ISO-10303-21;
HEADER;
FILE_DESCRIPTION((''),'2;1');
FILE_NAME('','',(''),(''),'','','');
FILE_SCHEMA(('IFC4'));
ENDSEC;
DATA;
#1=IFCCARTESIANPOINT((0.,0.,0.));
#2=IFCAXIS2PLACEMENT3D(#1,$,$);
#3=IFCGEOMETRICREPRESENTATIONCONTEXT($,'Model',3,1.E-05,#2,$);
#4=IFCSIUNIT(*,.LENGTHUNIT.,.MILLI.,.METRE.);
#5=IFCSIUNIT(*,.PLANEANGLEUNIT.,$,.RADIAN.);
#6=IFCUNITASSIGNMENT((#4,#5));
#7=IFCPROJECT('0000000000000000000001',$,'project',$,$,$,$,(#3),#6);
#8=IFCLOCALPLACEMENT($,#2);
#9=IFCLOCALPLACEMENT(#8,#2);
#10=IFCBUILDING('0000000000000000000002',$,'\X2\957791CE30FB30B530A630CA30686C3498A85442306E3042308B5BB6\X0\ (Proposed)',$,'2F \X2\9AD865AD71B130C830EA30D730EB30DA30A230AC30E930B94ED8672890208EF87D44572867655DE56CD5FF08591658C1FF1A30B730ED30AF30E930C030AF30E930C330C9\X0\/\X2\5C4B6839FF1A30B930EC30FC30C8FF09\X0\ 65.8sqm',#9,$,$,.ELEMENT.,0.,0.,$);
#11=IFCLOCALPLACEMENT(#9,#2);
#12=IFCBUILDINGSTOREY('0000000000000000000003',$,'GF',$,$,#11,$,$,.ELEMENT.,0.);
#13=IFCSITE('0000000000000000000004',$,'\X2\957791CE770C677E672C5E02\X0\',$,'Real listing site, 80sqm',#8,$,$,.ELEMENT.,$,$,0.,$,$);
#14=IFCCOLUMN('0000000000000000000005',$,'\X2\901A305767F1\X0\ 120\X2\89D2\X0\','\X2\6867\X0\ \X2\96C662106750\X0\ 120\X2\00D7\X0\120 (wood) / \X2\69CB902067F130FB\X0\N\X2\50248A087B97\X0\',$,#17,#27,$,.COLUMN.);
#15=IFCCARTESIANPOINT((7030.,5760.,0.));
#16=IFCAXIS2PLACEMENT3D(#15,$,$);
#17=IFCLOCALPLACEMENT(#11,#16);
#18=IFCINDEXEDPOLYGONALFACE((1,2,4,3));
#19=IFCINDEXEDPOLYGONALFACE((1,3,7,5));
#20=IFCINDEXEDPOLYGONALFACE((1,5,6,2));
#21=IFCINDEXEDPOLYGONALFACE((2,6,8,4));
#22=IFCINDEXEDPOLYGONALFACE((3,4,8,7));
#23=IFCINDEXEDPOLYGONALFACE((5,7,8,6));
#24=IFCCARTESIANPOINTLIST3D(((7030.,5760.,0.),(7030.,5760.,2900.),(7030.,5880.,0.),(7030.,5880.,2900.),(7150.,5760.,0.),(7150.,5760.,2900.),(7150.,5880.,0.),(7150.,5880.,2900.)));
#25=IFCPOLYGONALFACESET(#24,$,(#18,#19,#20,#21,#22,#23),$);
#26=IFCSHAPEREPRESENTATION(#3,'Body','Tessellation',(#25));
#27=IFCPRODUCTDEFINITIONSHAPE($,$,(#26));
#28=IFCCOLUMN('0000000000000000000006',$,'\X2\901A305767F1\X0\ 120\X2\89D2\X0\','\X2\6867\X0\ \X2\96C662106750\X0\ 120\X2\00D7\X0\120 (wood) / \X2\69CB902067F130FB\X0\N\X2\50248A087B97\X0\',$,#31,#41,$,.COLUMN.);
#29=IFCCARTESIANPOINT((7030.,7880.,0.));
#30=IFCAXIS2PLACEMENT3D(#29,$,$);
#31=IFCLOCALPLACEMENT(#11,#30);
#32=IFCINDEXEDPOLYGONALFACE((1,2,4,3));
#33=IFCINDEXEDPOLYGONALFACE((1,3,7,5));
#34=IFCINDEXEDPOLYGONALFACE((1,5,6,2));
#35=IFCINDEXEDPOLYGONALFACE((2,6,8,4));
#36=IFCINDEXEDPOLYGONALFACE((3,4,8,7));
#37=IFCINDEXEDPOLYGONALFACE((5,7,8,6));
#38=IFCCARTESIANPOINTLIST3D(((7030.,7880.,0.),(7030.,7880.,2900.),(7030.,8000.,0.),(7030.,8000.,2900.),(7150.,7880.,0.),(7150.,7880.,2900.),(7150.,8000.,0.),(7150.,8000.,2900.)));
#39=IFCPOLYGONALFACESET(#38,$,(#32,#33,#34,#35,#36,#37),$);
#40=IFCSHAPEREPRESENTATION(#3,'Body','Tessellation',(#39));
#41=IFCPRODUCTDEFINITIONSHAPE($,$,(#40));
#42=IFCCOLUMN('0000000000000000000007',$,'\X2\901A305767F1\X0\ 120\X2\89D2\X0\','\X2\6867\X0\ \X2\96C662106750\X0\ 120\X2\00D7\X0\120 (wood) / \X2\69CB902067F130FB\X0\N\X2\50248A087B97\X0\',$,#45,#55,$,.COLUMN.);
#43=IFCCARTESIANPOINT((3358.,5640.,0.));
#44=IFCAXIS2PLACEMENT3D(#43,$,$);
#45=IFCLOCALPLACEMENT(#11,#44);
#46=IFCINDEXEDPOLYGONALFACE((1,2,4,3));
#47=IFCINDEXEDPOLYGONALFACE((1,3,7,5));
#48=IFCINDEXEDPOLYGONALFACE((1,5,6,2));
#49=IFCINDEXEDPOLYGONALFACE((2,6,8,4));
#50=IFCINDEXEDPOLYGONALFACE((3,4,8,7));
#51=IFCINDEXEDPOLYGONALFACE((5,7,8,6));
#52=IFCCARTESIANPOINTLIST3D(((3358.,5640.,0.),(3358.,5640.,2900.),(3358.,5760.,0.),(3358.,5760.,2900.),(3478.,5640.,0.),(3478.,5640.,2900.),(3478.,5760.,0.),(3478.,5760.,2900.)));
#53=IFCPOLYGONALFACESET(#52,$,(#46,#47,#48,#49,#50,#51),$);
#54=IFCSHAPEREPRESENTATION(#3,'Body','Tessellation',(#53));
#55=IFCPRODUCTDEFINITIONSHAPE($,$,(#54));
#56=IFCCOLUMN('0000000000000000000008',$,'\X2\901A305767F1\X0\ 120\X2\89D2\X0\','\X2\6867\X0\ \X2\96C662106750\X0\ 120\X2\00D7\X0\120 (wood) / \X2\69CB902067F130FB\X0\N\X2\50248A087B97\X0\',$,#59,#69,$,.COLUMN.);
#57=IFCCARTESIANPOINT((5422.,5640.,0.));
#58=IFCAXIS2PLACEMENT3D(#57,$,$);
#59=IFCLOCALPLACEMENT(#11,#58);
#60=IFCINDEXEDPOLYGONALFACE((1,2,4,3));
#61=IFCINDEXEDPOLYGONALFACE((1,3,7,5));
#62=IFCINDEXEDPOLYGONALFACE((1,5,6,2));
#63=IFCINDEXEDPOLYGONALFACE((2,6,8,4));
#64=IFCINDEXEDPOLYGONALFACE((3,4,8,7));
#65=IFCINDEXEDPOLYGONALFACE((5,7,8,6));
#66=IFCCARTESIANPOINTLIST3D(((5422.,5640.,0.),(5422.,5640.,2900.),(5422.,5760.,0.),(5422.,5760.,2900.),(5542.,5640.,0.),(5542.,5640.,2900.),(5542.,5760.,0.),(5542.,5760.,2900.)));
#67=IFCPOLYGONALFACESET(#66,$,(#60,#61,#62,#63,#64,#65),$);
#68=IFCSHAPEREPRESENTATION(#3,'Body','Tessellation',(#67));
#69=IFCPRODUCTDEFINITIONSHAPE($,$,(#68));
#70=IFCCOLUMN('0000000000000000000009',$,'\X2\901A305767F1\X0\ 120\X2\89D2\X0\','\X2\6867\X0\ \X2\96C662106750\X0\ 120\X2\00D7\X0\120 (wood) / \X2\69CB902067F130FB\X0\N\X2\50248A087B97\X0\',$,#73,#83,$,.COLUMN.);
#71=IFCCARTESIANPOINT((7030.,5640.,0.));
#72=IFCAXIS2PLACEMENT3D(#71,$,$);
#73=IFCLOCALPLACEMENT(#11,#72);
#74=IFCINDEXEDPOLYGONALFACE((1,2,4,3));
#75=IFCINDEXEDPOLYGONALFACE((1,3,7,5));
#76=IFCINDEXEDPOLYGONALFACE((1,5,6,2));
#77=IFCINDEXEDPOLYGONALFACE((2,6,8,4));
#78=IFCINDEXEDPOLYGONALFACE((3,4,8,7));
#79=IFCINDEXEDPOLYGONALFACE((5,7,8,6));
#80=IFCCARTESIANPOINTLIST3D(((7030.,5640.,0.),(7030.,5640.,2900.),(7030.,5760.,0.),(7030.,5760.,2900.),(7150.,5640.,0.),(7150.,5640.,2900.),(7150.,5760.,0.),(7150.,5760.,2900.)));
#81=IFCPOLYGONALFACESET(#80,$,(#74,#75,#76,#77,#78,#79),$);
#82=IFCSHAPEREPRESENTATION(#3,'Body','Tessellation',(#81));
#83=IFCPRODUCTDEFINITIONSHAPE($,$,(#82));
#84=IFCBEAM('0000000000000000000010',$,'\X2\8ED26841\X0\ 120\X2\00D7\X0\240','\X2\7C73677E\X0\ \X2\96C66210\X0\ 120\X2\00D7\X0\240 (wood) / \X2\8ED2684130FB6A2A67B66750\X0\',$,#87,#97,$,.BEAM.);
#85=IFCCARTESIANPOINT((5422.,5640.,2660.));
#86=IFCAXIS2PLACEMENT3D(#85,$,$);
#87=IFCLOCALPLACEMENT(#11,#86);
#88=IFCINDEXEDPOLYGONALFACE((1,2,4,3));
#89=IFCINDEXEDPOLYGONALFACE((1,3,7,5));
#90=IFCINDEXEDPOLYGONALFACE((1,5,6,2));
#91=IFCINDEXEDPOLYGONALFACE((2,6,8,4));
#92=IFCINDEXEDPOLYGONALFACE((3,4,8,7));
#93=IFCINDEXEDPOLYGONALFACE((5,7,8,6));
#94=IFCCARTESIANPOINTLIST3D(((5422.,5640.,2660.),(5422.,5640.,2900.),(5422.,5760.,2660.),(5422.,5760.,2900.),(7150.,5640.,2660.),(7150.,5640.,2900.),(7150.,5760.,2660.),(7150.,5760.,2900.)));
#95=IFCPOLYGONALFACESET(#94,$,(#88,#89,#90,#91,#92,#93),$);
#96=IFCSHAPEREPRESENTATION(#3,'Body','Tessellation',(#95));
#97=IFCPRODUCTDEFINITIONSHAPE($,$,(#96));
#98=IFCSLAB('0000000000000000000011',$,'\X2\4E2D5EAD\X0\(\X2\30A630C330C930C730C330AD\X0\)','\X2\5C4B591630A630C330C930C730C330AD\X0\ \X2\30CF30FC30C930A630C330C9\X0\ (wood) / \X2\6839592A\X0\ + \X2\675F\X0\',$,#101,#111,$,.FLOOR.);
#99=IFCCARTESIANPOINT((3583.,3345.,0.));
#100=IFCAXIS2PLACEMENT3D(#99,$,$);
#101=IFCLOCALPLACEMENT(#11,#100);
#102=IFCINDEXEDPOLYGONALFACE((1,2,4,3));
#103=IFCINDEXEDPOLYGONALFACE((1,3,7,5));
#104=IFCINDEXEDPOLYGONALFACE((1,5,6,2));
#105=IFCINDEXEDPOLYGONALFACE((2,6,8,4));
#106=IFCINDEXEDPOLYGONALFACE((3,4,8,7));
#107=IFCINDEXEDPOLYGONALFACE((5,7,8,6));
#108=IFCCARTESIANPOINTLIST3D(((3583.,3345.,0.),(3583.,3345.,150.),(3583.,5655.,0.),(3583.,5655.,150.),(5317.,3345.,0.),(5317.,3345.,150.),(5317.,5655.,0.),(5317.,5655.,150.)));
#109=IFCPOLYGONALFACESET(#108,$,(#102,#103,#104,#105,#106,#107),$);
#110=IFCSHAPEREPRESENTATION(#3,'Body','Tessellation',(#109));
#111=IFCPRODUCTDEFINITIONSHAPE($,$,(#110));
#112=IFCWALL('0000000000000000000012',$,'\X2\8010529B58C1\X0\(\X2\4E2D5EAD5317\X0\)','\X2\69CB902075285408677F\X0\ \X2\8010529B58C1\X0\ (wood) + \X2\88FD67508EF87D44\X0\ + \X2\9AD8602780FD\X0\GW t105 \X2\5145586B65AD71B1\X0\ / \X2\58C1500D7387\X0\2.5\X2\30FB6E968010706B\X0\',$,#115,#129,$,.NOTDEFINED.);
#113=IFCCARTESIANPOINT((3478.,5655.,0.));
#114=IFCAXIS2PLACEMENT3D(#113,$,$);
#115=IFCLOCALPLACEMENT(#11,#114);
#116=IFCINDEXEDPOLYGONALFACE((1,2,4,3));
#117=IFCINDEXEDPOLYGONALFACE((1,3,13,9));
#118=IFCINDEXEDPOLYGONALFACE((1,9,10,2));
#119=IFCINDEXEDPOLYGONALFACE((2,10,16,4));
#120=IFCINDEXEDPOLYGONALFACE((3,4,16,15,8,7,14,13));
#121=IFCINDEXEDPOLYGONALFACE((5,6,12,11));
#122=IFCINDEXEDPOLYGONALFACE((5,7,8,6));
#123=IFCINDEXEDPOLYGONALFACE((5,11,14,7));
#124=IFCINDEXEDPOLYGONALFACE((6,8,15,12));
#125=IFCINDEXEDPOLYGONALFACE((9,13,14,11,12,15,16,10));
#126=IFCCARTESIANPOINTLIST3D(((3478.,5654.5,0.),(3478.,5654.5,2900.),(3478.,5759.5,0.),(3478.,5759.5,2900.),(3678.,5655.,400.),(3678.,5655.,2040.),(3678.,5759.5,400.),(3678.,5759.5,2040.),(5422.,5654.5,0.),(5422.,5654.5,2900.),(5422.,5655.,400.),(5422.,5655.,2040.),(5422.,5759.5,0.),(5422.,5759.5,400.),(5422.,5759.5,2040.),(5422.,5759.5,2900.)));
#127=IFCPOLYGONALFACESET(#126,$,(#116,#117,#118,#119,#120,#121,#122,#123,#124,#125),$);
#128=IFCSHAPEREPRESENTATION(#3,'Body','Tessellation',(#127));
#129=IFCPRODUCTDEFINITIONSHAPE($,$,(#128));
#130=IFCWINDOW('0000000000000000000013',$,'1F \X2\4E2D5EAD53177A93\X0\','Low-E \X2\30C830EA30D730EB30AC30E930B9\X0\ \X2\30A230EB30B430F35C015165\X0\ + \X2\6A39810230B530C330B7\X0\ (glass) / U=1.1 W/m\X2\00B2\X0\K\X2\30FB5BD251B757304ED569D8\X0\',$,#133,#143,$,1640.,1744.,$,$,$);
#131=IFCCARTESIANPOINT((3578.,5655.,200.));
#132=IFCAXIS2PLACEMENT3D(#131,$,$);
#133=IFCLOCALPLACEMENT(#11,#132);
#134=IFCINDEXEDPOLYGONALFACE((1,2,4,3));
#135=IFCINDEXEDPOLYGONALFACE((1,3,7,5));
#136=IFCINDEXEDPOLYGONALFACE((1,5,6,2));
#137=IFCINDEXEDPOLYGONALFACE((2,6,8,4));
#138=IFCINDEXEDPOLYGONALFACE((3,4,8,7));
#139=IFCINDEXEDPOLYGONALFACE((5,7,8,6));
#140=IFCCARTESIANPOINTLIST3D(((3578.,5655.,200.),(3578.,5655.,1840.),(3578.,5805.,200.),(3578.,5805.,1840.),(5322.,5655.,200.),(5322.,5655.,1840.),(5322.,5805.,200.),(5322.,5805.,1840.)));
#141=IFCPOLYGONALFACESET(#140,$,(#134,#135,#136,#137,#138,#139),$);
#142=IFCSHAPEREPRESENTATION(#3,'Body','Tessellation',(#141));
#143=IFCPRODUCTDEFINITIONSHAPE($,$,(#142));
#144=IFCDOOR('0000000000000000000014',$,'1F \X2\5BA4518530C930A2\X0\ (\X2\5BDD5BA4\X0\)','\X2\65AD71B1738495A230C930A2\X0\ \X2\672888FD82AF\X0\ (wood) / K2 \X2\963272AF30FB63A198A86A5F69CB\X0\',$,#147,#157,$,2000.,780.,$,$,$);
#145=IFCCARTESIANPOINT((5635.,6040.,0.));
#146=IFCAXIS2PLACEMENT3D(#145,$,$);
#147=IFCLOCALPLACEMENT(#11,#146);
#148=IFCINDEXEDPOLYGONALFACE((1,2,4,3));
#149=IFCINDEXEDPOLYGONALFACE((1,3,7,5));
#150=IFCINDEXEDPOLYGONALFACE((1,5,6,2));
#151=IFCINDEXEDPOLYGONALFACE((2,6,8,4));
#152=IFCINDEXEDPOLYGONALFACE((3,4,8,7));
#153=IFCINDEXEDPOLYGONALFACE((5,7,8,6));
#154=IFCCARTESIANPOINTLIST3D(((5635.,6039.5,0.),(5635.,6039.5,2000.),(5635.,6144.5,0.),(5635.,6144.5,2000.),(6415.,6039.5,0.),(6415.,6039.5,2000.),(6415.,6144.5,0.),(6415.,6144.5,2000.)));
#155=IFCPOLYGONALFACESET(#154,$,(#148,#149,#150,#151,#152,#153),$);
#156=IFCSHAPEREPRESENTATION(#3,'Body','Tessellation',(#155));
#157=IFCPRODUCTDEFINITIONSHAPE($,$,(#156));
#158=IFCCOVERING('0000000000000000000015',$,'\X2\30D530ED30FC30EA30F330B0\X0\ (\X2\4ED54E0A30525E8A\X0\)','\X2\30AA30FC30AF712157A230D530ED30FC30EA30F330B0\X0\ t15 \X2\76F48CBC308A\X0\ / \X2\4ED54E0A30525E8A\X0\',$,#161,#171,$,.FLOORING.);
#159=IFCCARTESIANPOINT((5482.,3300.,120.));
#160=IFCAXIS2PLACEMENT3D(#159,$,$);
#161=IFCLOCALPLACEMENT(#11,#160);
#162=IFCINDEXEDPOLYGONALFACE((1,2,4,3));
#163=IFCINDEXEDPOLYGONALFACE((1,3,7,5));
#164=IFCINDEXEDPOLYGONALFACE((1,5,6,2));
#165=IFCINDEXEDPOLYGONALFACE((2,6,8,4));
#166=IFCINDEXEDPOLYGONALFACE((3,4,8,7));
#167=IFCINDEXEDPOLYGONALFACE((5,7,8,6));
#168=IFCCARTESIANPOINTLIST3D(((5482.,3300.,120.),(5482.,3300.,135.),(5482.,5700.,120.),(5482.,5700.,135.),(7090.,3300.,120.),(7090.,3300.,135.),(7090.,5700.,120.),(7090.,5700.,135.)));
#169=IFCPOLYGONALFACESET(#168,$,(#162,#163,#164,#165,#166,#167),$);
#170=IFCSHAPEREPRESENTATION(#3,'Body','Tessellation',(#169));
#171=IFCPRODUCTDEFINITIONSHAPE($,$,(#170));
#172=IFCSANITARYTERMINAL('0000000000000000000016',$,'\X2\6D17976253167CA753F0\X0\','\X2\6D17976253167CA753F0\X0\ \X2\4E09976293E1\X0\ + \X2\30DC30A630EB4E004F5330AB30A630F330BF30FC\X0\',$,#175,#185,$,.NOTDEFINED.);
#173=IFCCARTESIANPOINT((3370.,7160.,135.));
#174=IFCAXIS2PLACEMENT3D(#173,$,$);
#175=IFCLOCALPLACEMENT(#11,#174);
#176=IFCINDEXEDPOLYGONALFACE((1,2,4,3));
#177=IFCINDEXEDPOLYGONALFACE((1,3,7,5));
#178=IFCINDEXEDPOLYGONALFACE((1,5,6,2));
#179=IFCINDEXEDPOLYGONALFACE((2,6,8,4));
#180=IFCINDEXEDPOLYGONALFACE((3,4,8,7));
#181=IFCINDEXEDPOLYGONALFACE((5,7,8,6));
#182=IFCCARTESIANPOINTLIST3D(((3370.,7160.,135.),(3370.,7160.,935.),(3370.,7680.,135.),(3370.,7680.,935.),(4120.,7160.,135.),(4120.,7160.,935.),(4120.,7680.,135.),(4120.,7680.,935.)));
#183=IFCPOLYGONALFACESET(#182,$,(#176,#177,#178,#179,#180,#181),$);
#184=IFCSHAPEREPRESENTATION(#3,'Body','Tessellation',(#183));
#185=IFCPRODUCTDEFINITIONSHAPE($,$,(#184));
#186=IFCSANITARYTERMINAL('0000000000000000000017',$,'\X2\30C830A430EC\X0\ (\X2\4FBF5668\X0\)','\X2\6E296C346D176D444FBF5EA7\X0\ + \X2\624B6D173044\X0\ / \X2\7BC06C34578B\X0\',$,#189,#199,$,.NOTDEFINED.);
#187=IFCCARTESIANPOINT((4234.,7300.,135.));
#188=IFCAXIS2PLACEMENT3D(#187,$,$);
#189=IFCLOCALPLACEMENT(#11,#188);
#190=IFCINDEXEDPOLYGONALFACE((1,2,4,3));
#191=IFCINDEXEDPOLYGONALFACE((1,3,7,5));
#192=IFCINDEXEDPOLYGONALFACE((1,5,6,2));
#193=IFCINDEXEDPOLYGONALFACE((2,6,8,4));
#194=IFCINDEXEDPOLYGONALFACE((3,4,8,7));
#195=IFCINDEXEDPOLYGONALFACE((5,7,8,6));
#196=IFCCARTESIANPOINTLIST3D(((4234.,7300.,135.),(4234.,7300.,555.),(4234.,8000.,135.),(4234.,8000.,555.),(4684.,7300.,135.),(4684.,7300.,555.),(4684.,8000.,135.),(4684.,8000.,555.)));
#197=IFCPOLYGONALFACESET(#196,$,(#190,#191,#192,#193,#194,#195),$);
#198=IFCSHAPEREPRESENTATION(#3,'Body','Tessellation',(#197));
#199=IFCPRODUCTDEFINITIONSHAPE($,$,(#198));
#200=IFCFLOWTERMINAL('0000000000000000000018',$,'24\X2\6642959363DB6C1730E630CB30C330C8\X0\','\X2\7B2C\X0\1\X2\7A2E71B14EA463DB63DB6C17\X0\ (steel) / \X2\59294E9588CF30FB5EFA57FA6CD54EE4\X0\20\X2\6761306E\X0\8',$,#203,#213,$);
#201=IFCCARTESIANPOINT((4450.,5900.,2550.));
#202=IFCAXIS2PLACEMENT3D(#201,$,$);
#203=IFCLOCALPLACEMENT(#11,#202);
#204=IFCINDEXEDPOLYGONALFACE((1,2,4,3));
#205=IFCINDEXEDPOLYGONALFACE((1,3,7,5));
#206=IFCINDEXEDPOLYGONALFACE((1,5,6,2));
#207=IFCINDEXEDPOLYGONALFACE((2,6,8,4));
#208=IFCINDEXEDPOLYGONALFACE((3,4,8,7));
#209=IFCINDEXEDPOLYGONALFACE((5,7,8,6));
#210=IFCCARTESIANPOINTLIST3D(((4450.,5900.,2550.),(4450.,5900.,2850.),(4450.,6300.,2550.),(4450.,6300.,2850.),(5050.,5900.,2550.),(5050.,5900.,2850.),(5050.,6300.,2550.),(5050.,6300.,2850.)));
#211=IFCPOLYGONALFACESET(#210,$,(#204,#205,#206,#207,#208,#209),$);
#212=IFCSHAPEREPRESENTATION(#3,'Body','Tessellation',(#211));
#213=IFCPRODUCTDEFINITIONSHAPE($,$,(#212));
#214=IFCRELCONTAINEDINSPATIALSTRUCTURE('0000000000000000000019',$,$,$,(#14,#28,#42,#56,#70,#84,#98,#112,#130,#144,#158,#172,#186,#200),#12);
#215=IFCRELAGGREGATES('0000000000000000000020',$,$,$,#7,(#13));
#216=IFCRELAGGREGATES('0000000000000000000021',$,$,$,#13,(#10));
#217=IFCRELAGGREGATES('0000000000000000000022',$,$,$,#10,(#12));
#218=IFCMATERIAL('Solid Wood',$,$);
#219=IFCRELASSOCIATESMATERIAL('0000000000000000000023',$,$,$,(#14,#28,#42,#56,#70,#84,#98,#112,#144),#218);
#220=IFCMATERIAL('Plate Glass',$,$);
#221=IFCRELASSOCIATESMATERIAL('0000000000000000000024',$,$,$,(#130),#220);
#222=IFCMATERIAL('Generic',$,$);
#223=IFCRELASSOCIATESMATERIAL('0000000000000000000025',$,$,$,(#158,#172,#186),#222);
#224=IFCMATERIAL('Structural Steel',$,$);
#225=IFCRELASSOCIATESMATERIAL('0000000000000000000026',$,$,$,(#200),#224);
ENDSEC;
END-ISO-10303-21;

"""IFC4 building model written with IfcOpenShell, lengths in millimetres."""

from ifc_helpers import new_model, si_unit, frame, frame_2d, origin, place, context, project, spatial, rectangle, extrude, material, element, fill, save


model = new_model("IFC4")

# Units and contexts
model_context = context("Model", 3, precision=1e-05, world=origin())
ifc_project = project(units=[si_unit("LENGTHUNIT", "METRE", prefix="MILLI"), si_unit("PLANEANGLEUNIT", "RADIAN")], contexts=[model_context])

# Site, building, storey
site_placement = place(None, origin())
site = spatial("IfcSite", under=ifc_project, at=site_placement, Name="長野県松本市", ObjectType="Real listing site, 80sqm", CompositionType="ELEMENT", RefElevation=0.0)
building_placement = place(site_placement, origin())
building = spatial("IfcBuilding", under=site, at=building_placement, Name="長野・サウナと水風呂のある家 (Proposed)", ObjectType="2F 高断熱トリプルペアガラス付木造軸組在来工法（外壁：シロクラダクラッド/屋根：スレート） 65.8sqm", CompositionType="ELEMENT", ElevationOfRefHeight=0.0, ElevationOfTerrain=0.0)
storey_placement = place(building_placement, origin())
storey = spatial("IfcBuildingStorey", under=building, at=storey_placement, Name="GF", CompositionType="ELEMENT", Elevation=0.0)

# Columns
ifc_material_1 = material(Name="Solid Wood")
column_1_placement = place(storey_placement, frame((7030.0, 5760.0, 0.0)))
element("IfcColumn", 1, at=column_1_placement, inside=storey, material=ifc_material_1, Name="通し柱 120角", Description="桧 集成材 120×120 (wood) / 構造柱・N値計算", PredefinedType="COLUMN", context=model_context, shape_type="SweptSolid", body=[
    extrude(rectangle(XDim=120.0, YDim=120.0, at=frame_2d((60.0, 60.0))), frame((7030.0, 5760.0, 0.0)), (0.0, 0.0, 1.0), 2900.0),
])
column_2_placement = place(storey_placement, frame((7030.0, 7880.0, 0.0)))
element("IfcColumn", 2, at=column_2_placement, inside=storey, material=ifc_material_1, Name="通し柱 120角", Description="桧 集成材 120×120 (wood) / 構造柱・N値計算", PredefinedType="COLUMN", context=model_context, shape_type="SweptSolid", body=[
    extrude(rectangle(XDim=120.0, YDim=120.0, at=frame_2d((60.0, 60.0))), frame((7030.0, 7880.0, 0.0)), (0.0, 0.0, 1.0), 2900.0),
])
column_3_placement = place(storey_placement, frame((3358.0, 5640.0, 0.0)))
element("IfcColumn", 3, at=column_3_placement, inside=storey, material=ifc_material_1, Name="通し柱 120角", Description="桧 集成材 120×120 (wood) / 構造柱・N値計算", PredefinedType="COLUMN", context=model_context, shape_type="SweptSolid", body=[
    extrude(rectangle(XDim=120.0, YDim=120.0, at=frame_2d((60.0, 60.0))), frame((3358.0, 5640.0, 0.0)), (0.0, 0.0, 1.0), 2900.0),
])
column_4_placement = place(storey_placement, frame((5422.0, 5640.0, 0.0)))
element("IfcColumn", 4, at=column_4_placement, inside=storey, material=ifc_material_1, Name="通し柱 120角", Description="桧 集成材 120×120 (wood) / 構造柱・N値計算", PredefinedType="COLUMN", context=model_context, shape_type="SweptSolid", body=[
    extrude(rectangle(XDim=120.0, YDim=120.0, at=frame_2d((60.0, 60.0))), frame((5422.0, 5640.0, 0.0)), (0.0, 0.0, 1.0), 2900.0),
])
column_5_placement = place(storey_placement, frame((7030.0, 5640.0, 0.0)))
element("IfcColumn", 5, at=column_5_placement, inside=storey, material=ifc_material_1, Name="通し柱 120角", Description="桧 集成材 120×120 (wood) / 構造柱・N値計算", PredefinedType="COLUMN", context=model_context, shape_type="SweptSolid", body=[
    extrude(rectangle(XDim=120.0, YDim=120.0, at=frame_2d((60.0, 60.0))), frame((7030.0, 5640.0, 0.0)), (0.0, 0.0, 1.0), 2900.0),
])

# Beam
beam_1_placement = place(storey_placement, frame((5422.0, 5640.0, 2660.0)))
element("IfcBeam", 6, at=beam_1_placement, inside=storey, material=ifc_material_1, Name="軒桁 120×240", Description="米松 集成 120×240 (wood) / 軒桁・横架材", PredefinedType="BEAM", context=model_context, shape_type="SweptSolid", body=[
    extrude(rectangle(XDim=1728.0, YDim=120.0, at=frame_2d((864.0, 60.0))), frame((5422.0, 5640.0, 2660.0)), (0.0, 0.0, 1.0), 240.0),
])

# Slab
slab_placement = place(storey_placement, frame((3583.0, 3345.0, 0.0)))
element("IfcSlab", 7, at=slab_placement, inside=storey, material=ifc_material_1, Name="中庭(ウッドデッキ)", Description="屋外ウッドデッキ ハードウッド (wood) / 根太 + 束", PredefinedType="FLOOR", context=model_context, shape_type="SweptSolid", body=[
    extrude(rectangle(XDim=1734.0, YDim=2310.0, at=frame_2d((867.0, 1155.0))), frame((3583.0, 3345.0, 0.0)), (0.0, 0.0, 1.0), 150.0),
])

# Wall, opening, window
wall_1_placement = place(storey_placement, frame((3478.0, 5655.0, 0.0)))
wall_1 = element("IfcWall", 8, at=wall_1_placement, inside=storey, material=ifc_material_1, Name="耐力壁(中庭北)", Description="構造用合板 耐力壁 (wood) + 製材軸組 + 高性能GW t105 充填断熱 / 壁倍率2.5・準耐火", PredefinedType="NOTDEFINED", context=model_context, shape_type="SweptSolid", body=[
    extrude(rectangle(XDim=1944.0, YDim=105.0, at=frame_2d((972.0, 52.0))), frame((3478.0, 5655.0, 0.0)), (0.0, 0.0, 1.0), 2900.0),
])
opening_placement = place(storey_placement, frame((3578.0, 5655.0, 200.0)))
opening = element("IfcOpeningElement", 9, at=opening_placement, cuts=wall_1, PredefinedType="NOTDEFINED", context=model_context, shape_type="SweptSolid", body=[
    extrude(rectangle(XDim=1744.0, YDim=150.0, at=frame_2d((872.0, 75.0))), frame((3578.0, 5655.0, 200.0)), (0.0, 0.0, 1.0), 1640.0),
])
ifc_material_2 = material(Name="Plate Glass")
window_placement = place(storey_placement, frame((3578.0, 5655.0, 200.0)))
window = element("IfcWindow", 10, at=window_placement, inside=storey, material=ifc_material_2, Name="1F 中庭北窓", Description="Low-E トリプルガラス アルゴン封入 + 樹脂サッシ (glass) / U=1.1 W/m²K・寒冷地仕様", OverallHeight=1640.0, OverallWidth=1744.0, context=model_context, shape_type="SweptSolid", body=[
    extrude(rectangle(XDim=1744.0, YDim=150.0, at=frame_2d((872.0, 75.0))), frame((3578.0, 5655.0, 200.0)), (0.0, 0.0, 1.0), 1640.0),
])
fill(opening, window)

# Door
door_placement = place(storey_placement, frame((5635.0, 6040.0, 0.0)))
element("IfcDoor", 11, at=door_placement, inside=storey, material=ifc_material_1, Name="1F 室内ドア (寝室)", Description="断熱玄関ドア 木製芯 (wood) / K2 防犯・採風機構", OverallHeight=2000.0, OverallWidth=780.0, context=model_context, shape_type="SweptSolid", body=[
    extrude(rectangle(XDim=780.0, YDim=105.0, at=frame_2d((390.0, 52.0))), frame((5635.0, 6040.0, 0.0)), (0.0, 0.0, 1.0), 2000.0),
])

# Covering
ifc_material_3 = material(Name="Generic")
covering_placement = place(storey_placement, frame((5482.0, 3300.0, 120.0)))
element("IfcCovering", 12, at=covering_placement, inside=storey, material=ifc_material_3, Name="フローリング (仕上げ床)", Description="オーク無垢フローリング t15 直貼り / 仕上げ床", PredefinedType="FLOORING", context=model_context, shape_type="SweptSolid", body=[
    extrude(rectangle(XDim=1608.0, YDim=2400.0, at=frame_2d((804.0, 1200.0))), frame((5482.0, 3300.0, 120.0)), (0.0, 0.0, 1.0), 15.0),
])

# Sanitary terminals
sanitary_terminal_1_placement = place(storey_placement, frame((3370.0, 7160.0, 135.0)))
element("IfcSanitaryTerminal", 13, at=sanitary_terminal_1_placement, inside=storey, material=ifc_material_3, Name="洗面化粧台", Description="洗面化粧台 三面鏡 + ボウル一体カウンター", PredefinedType="NOTDEFINED", context=model_context, shape_type="SweptSolid", body=[
    extrude(rectangle(XDim=750.0, YDim=520.0, at=frame_2d((375.0, 260.0))), frame((3370.0, 7160.0, 135.0)), (0.0, 0.0, 1.0), 800.0),
])
sanitary_terminal_2_placement = place(storey_placement, frame((4234.0, 7300.0, 135.0)))
element("IfcSanitaryTerminal", 14, at=sanitary_terminal_2_placement, inside=storey, material=ifc_material_3, Name="トイレ (便器)", Description="温水洗浄便座 + 手洗い / 節水型", PredefinedType="NOTDEFINED", context=model_context, shape_type="SweptSolid", body=[
    extrude(rectangle(XDim=450.0, YDim=700.0, at=frame_2d((225.0, 350.0))), frame((4234.0, 7300.0, 135.0)), (0.0, 0.0, 1.0), 420.0),
])

# Flow terminal
ifc_material_4 = material(Name="Structural Steel")
flow_terminal_placement = place(storey_placement, frame((4450.0, 5900.0, 2550.0)))
element("IfcFlowTerminal", 15, at=flow_terminal_placement, inside=storey, material=ifc_material_4, Name="24時間換気ユニット", Description="第1種熱交換換気 (steel) / 天井裏・建基法令20条の8", context=model_context, shape_type="SweptSolid", body=[
    extrude(rectangle(XDim=600.0, YDim=400.0, at=frame_2d((300.0, 200.0))), frame((4450.0, 5900.0, 2550.0)), (0.0, 0.0, 1.0), 300.0),
])

save(model, "model.ifc")
